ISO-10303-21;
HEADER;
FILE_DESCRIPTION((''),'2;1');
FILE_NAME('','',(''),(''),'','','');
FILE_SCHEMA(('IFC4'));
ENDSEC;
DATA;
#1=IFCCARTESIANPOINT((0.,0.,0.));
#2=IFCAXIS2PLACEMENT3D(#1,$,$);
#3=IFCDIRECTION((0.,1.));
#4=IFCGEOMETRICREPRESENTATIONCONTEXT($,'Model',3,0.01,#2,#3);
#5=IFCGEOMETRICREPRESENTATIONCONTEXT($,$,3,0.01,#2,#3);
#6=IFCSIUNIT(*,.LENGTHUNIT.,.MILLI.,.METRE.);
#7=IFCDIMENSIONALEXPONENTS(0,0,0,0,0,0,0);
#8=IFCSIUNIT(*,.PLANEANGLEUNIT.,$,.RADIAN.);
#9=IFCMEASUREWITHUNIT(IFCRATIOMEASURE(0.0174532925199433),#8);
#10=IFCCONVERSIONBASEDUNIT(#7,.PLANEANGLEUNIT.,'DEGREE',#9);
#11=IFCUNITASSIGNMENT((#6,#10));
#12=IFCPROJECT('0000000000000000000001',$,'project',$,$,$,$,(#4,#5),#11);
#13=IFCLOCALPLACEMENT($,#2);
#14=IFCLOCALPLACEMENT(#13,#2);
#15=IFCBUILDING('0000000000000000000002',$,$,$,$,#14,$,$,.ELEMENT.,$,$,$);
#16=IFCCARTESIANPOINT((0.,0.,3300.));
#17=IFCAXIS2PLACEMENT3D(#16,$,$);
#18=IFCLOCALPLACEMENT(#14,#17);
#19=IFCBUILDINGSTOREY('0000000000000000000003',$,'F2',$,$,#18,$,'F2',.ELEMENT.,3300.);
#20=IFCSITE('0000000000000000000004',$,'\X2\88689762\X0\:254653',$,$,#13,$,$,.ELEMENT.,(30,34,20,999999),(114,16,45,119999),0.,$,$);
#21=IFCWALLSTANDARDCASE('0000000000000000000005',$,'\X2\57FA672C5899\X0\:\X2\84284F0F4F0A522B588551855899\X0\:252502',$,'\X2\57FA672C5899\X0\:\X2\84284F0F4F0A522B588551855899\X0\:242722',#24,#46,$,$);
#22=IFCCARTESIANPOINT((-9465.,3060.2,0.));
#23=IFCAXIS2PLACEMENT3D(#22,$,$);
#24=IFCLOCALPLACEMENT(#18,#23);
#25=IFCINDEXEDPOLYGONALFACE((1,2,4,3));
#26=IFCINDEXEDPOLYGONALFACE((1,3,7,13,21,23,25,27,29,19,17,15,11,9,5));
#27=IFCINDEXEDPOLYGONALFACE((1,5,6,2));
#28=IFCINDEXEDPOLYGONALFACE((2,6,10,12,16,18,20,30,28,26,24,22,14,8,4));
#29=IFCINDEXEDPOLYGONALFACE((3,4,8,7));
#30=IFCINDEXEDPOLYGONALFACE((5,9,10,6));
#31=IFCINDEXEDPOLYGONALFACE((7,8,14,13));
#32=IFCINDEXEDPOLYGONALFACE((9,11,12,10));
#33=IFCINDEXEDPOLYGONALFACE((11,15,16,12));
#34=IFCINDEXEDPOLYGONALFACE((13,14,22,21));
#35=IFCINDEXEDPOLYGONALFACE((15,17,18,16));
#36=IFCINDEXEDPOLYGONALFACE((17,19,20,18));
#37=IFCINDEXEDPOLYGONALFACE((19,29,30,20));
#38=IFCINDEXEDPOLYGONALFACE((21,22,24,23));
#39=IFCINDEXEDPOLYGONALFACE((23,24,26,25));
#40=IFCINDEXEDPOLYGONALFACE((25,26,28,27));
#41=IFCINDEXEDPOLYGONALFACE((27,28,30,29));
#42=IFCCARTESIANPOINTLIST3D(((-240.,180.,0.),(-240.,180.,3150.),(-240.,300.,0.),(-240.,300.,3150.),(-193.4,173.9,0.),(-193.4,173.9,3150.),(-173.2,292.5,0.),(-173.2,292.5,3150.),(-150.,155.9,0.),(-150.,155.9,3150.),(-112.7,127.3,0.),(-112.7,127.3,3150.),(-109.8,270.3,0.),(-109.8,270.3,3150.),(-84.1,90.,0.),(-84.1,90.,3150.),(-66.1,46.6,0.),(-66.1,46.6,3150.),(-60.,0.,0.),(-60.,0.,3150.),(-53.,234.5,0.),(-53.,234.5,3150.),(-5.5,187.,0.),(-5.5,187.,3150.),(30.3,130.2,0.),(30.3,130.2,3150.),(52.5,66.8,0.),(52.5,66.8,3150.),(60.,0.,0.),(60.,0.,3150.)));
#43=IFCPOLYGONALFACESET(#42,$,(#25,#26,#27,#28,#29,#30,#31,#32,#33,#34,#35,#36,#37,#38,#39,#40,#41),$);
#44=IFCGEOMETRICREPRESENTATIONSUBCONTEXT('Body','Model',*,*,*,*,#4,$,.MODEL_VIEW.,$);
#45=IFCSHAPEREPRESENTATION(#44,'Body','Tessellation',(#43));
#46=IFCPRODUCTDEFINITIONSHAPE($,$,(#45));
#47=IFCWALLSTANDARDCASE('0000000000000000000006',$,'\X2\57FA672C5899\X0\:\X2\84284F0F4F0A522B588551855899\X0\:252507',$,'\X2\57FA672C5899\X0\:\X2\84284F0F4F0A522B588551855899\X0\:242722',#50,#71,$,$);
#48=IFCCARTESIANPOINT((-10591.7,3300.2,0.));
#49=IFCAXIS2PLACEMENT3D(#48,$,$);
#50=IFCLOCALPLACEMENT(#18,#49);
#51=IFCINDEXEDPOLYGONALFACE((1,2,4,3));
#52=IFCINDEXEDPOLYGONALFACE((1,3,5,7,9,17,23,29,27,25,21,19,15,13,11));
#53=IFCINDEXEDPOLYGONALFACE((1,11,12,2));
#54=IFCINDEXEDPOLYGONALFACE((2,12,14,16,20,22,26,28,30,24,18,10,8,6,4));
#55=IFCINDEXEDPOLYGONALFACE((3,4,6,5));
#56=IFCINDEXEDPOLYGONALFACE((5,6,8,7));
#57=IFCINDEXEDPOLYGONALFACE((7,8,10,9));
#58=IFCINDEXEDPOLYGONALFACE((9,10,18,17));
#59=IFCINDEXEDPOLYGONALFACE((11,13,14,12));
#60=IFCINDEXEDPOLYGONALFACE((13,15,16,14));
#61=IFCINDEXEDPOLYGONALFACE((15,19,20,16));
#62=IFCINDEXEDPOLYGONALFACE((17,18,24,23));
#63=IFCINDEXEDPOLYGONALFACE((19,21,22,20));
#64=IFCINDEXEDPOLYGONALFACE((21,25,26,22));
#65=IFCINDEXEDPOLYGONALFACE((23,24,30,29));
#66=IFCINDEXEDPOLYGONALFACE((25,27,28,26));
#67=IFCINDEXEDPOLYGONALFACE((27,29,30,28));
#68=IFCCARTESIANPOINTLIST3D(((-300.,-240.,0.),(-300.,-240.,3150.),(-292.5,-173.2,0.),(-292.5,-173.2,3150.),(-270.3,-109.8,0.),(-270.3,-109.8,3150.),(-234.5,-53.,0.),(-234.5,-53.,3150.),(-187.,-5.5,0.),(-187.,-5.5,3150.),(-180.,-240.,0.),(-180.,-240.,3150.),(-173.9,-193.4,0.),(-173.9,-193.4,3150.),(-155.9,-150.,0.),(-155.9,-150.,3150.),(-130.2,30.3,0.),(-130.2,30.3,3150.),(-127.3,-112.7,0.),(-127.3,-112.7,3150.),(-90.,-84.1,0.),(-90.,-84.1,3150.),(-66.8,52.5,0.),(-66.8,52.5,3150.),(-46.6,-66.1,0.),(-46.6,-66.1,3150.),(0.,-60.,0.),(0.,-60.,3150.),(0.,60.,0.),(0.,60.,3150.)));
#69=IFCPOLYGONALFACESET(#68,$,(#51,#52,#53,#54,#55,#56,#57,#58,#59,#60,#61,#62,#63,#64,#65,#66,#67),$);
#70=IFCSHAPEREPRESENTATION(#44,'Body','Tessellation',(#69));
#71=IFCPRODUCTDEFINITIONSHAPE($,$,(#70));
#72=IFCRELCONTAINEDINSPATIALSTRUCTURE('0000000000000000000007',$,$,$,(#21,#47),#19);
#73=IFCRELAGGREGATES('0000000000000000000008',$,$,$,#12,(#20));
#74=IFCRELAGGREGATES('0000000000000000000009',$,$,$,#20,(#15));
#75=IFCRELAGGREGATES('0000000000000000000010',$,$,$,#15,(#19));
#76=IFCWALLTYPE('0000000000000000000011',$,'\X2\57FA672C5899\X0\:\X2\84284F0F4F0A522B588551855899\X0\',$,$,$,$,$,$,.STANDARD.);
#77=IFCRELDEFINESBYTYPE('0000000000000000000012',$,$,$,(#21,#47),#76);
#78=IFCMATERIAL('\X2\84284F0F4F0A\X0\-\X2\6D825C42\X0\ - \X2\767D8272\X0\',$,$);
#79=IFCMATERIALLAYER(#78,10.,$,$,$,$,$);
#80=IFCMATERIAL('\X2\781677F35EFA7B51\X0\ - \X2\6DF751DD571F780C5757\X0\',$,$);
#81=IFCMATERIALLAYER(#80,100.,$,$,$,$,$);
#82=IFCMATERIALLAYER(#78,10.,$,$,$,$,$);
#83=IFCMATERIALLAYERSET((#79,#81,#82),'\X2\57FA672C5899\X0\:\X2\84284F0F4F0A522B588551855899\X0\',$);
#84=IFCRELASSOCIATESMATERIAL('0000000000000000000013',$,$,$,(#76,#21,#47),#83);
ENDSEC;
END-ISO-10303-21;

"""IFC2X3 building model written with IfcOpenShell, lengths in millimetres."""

from ifc_helpers import new_model, entity, si_unit, converted_unit, direction, frame, frame_2d, origin, place, context, subcontext, project, spatial, polyline, circle_curve, parameter, trimmed, segment, composite_curve, outline, extrude, clip, halfspace, material, layer, layer_set, layer_usage, type_object, element, save


model = new_model("IFC2X3")

# Units and contexts
model_context = context("Model", 3, precision=0.01, world=origin(), true_north=direction((0.0, 1.0)))
context_of_model = context(None, 3, precision=0.01, world=origin(), true_north=direction((0.0, 1.0)))
body_context = subcontext(model_context, "Body", "Model", "MODEL_VIEW")
ifc_project = project(units=[si_unit("LENGTHUNIT", "METRE", prefix="MILLI"), converted_unit("PLANEANGLEUNIT", "DEGREE", entity("IfcRatioMeasure", 0.0174532925199433), si_unit("PLANEANGLEUNIT", "RADIAN"), dimensions=[0, 0, 0, 0, 0, 0, 0])], contexts=[model_context, context_of_model])

# Site, building, storey
site_placement = place(None, origin())
site = spatial("IfcSite", under=ifc_project, at=site_placement, Name="表面:254653", CompositionType="ELEMENT", RefLatitude=(30, 34, 20, 999999), RefLongitude=(114, 16, 45, 119999), RefElevation=0.0)
building_placement = place(site_placement, origin())
building = spatial("IfcBuilding", under=site, at=building_placement, CompositionType="ELEMENT")
storey_placement = place(building_placement, frame((0.0, 0.0, 3300.0)))
storey = spatial("IfcBuildingStorey", under=building, at=storey_placement, Name="F2", LongName="F2", CompositionType="ELEMENT", Elevation=3300.0)

# Shared definitions
ifc_material_1 = material(Name="萨伏伊-涂层 - 白色")
ifc_layer_1 = layer(ifc_material_1, 10.0)
ifc_material_2 = material(Name="砖石建筑 - 混凝土砌块")
ifc_layer_2 = layer(ifc_material_2, 100.0)
ifc_layer_3 = layer(ifc_material_1, 10.0)
ifc_layer_set_1 = layer_set([ifc_layer_1, ifc_layer_2, ifc_layer_3], Name="基本墙:萨伏伊别墅内墙")
wall_type_1 = type_object("IfcWallType", Name="基本墙:萨伏伊别墅内墙", PredefinedType="STANDARD", material=ifc_layer_set_1)

# Walls
ifc_layer_usage_1 = layer_usage(ifc_layer_set_1, "AXIS2", "NEGATIVE", 60.0)
wall_1_placement = place(storey_placement, frame((-9465.0, 3060.2, 0.0)))
element("IfcWallStandardCase", 1, at=wall_1_placement, inside=storey, type_object=wall_type_1, material=ifc_layer_usage_1, Name="基本墙:萨伏伊别墅内墙:252502", ObjectType="基本墙:萨伏伊别墅内墙:242722", context=body_context, shape_type="Clipping", body=[
    clip(extrude(outline(composite_curve([segment(trimmed(circle_curve(frame_2d((-240.0, 0.0), x_axis=(1.0, 0.0)), 180.0), [parameter(0.0)], [parameter(90.0)], True, "PARAMETER"), False, "CONTINUOUS"), segment(polyline([(-60.0, 0.0), (60.0, 0.0)]), True, "CONTINUOUS"), segment(trimmed(circle_curve(frame_2d((-240.0, 0.0), x_axis=(1.0, 0.0)), 300.0), [parameter(0.0)], [parameter(90.0)], True, "PARAMETER"), True, "CONTINUOUS"), segment(polyline([(-240.0, 300.0), (-240.0, 180.0)]), True, "CONTINUOUS")], self_intersect=False)), origin(), (0.0, 0.0, 1.0), 3150.0), halfspace(frame((-240.0, 180.0, 3150.0), z_axis=(0.0, 0.0, -1.0), x_axis=(0.0, -1.0, 0.0)), True)),
])
ifc_layer_usage_2 = layer_usage(ifc_layer_set_1, "AXIS2", "NEGATIVE", 60.0)
wall_2_placement = place(storey_placement, frame((-10591.7, 3300.2, 0.0)))
element("IfcWallStandardCase", 2, at=wall_2_placement, inside=storey, type_object=wall_type_1, material=ifc_layer_usage_2, Name="基本墙:萨伏伊别墅内墙:252507", ObjectType="基本墙:萨伏伊别墅内墙:242722", context=body_context, shape_type="Clipping", body=[
    clip(extrude(outline(composite_curve([segment(trimmed(circle_curve(frame_2d((0.0, -240.0), x_axis=(1.0, 0.0)), 180.0), [parameter(90.0)], [parameter(180.0)], True, "PARAMETER"), False, "CONTINUOUS"), segment(polyline([(0.0, -60.0), (0.0, 60.0)]), True, "CONTINUOUS"), segment(trimmed(circle_curve(frame_2d((0.0, -240.0), x_axis=(1.0, 0.0)), 300.0), [parameter(90.0)], [parameter(180.0)], True, "PARAMETER"), True, "CONTINUOUS"), segment(polyline([(-300.0, -240.0), (-180.0, -240.0)]), True, "CONTINUOUS")], self_intersect=False)), origin(), (0.0, 0.0, 1.0), 3150.0), halfspace(frame((-180.0, -240.0, 3150.0), z_axis=(0.0, 0.0, -1.0), x_axis=(0.0, -1.0, 0.0)), True)),
])

save(model, "model.ifc")
